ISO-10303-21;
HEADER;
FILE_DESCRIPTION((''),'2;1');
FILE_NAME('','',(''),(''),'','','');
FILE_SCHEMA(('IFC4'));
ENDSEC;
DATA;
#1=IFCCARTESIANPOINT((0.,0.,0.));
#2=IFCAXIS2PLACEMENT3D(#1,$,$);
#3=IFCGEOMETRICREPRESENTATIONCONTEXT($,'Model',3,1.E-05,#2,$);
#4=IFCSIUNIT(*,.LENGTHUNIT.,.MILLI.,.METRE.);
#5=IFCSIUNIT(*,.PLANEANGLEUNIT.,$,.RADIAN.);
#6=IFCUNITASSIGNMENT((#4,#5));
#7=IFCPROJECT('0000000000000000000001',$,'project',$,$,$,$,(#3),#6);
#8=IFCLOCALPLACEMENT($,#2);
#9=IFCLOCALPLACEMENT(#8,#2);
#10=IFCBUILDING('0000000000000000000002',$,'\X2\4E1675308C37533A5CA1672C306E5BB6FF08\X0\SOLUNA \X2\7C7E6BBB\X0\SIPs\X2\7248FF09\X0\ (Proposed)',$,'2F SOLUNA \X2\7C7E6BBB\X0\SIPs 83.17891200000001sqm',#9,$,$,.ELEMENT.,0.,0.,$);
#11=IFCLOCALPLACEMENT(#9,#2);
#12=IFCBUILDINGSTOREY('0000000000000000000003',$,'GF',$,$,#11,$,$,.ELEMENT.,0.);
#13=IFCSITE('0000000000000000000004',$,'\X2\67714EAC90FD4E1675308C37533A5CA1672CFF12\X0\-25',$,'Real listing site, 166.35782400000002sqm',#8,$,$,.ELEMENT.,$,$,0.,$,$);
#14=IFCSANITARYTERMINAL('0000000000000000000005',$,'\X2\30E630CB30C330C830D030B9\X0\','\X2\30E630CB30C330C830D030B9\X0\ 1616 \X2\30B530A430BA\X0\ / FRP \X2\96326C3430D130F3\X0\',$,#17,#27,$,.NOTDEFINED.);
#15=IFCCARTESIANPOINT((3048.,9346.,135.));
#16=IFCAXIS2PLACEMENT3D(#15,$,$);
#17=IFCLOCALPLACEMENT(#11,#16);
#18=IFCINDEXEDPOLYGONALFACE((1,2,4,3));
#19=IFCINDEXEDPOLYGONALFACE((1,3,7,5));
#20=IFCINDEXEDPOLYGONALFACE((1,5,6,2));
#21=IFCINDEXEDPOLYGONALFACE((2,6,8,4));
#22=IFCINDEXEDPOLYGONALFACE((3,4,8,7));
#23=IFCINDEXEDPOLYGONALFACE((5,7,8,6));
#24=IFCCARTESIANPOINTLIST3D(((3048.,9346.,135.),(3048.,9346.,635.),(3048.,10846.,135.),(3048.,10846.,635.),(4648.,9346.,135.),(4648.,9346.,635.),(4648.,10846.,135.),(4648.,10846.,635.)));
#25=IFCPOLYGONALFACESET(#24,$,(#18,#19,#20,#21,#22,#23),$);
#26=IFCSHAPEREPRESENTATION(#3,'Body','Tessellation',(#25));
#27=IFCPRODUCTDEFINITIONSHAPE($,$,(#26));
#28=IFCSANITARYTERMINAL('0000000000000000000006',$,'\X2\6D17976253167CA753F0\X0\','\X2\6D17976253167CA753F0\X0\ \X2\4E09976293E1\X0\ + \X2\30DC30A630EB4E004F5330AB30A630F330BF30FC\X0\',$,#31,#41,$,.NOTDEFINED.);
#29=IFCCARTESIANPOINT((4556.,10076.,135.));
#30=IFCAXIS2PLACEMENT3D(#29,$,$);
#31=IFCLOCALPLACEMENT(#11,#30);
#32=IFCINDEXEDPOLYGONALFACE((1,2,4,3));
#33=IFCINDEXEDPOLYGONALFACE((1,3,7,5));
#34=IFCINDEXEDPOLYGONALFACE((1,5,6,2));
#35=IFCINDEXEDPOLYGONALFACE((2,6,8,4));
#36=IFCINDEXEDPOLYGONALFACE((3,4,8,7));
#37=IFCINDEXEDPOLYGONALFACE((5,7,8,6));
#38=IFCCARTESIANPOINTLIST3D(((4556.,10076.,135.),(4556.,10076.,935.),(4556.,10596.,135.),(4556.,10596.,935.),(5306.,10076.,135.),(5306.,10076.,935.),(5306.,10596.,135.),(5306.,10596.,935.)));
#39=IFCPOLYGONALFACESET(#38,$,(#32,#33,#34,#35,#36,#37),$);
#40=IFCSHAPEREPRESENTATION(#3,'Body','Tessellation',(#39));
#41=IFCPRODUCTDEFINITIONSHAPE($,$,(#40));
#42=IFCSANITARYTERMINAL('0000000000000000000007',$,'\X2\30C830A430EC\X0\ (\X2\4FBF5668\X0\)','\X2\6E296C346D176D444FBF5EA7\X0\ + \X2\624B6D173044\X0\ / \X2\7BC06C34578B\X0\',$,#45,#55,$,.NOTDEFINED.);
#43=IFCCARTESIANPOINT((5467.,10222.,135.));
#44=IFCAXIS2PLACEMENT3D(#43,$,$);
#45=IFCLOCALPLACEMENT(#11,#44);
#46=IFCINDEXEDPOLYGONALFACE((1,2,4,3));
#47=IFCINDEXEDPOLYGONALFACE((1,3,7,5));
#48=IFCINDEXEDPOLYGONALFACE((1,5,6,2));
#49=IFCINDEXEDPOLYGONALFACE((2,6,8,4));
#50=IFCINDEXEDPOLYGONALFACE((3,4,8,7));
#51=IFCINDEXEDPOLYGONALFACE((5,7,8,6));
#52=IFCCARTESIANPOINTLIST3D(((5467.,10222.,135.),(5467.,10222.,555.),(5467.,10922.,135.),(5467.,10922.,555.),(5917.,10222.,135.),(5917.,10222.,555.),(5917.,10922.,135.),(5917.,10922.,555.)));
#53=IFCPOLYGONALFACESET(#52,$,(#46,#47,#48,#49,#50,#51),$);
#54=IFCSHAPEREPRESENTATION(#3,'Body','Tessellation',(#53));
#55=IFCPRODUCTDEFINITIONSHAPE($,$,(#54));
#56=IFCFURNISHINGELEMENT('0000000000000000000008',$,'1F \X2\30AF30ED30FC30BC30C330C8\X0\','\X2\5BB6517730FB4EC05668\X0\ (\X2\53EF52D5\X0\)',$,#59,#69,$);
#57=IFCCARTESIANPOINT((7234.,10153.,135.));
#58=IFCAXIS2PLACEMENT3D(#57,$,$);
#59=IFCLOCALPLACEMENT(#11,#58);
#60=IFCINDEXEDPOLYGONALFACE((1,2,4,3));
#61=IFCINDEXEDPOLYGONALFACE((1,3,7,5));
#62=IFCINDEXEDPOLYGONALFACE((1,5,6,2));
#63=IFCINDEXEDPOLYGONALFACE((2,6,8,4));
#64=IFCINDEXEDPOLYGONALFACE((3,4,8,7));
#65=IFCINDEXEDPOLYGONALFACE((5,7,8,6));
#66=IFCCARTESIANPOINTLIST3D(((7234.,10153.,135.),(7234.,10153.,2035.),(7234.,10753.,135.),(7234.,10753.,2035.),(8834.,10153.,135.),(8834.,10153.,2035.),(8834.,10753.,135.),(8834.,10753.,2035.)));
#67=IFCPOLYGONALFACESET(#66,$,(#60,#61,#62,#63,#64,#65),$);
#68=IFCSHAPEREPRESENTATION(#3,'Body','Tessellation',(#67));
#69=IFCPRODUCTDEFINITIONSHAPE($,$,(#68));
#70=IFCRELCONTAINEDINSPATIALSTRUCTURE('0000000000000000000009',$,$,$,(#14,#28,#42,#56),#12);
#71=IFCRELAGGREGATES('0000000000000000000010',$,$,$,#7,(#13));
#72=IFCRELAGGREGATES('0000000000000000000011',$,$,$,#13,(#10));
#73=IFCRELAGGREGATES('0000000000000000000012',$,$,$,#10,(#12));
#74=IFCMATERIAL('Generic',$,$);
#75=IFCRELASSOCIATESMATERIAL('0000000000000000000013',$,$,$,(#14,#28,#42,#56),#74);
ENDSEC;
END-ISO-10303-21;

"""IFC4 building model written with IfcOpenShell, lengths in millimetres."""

from ifc_helpers import new_model, si_unit, frame, frame_2d, origin, place, context, project, spatial, rectangle, extrude, material, element, save


model = new_model("IFC4")

# Units and contexts
model_context = context("Model", 3, precision=1e-05, world=origin())
ifc_project = project(units=[si_unit("LENGTHUNIT", "METRE", prefix="MILLI"), si_unit("PLANEANGLEUNIT", "RADIAN")], contexts=[model_context])

# Site, building, storey
site_placement = place(None, origin())
site = spatial("IfcSite", under=ifc_project, at=site_placement, Name="東京都世田谷区岡本２-25", ObjectType="Real listing site, 166.35782400000002sqm", CompositionType="ELEMENT", RefElevation=0.0)
building_placement = place(site_placement, origin())
building = spatial("IfcBuilding", under=site, at=building_placement, Name="世田谷区岡本の家（SOLUNA 籾殻SIPs版） (Proposed)", ObjectType="2F SOLUNA 籾殻SIPs 83.17891200000001sqm", CompositionType="ELEMENT", ElevationOfRefHeight=0.0, ElevationOfTerrain=0.0)
storey_placement = place(building_placement, origin())
storey = spatial("IfcBuildingStorey", under=building, at=storey_placement, Name="GF", CompositionType="ELEMENT", Elevation=0.0)

# Shared definitions
ifc_material_1 = material(Name="Generic")

# Sanitary terminals
sanitary_terminal_1_placement = place(storey_placement, frame((3048.0, 9346.0, 135.0)))
element("IfcSanitaryTerminal", 1, at=sanitary_terminal_1_placement, inside=storey, material=ifc_material_1, Name="ユニットバス", Description="ユニットバス 1616 サイズ / FRP 防水パン", PredefinedType="NOTDEFINED", context=model_context, shape_type="SweptSolid", body=[
    extrude(rectangle(XDim=1600.0, YDim=1500.0, at=frame_2d((800.0, 750.0))), frame((3048.0, 9346.0, 135.0)), (0.0, 0.0, 1.0), 500.0),
])
sanitary_terminal_2_placement = place(storey_placement, frame((4556.0, 10076.0, 135.0)))
element("IfcSanitaryTerminal", 2, at=sanitary_terminal_2_placement, inside=storey, material=ifc_material_1, Name="洗面化粧台", Description="洗面化粧台 三面鏡 + ボウル一体カウンター", PredefinedType="NOTDEFINED", context=model_context, shape_type="SweptSolid", body=[
    extrude(rectangle(XDim=750.0, YDim=520.0, at=frame_2d((375.0, 260.0))), frame((4556.0, 10076.0, 135.0)), (0.0, 0.0, 1.0), 800.0),
])
sanitary_terminal_3_placement = place(storey_placement, frame((5467.0, 10222.0, 135.0)))
element("IfcSanitaryTerminal", 3, at=sanitary_terminal_3_placement, inside=storey, material=ifc_material_1, Name="トイレ (便器)", Description="温水洗浄便座 + 手洗い / 節水型", PredefinedType="NOTDEFINED", context=model_context, shape_type="SweptSolid", body=[
    extrude(rectangle(XDim=450.0, YDim=700.0, at=frame_2d((225.0, 350.0))), frame((5467.0, 10222.0, 135.0)), (0.0, 0.0, 1.0), 420.0),
])

# Furnishing element
furnishing_placement = place(storey_placement, frame((7234.0, 10153.0, 135.0)))
element("IfcFurnishingElement", 4, at=furnishing_placement, inside=storey, material=ifc_material_1, Name="1F クローゼット", Description="家具・什器 (可動)", context=model_context, shape_type="SweptSolid", body=[
    extrude(rectangle(XDim=1600.0, YDim=600.0, at=frame_2d((800.0, 300.0))), frame((7234.0, 10153.0, 135.0)), (0.0, 0.0, 1.0), 1900.0),
])

save(model, "model.ifc")
